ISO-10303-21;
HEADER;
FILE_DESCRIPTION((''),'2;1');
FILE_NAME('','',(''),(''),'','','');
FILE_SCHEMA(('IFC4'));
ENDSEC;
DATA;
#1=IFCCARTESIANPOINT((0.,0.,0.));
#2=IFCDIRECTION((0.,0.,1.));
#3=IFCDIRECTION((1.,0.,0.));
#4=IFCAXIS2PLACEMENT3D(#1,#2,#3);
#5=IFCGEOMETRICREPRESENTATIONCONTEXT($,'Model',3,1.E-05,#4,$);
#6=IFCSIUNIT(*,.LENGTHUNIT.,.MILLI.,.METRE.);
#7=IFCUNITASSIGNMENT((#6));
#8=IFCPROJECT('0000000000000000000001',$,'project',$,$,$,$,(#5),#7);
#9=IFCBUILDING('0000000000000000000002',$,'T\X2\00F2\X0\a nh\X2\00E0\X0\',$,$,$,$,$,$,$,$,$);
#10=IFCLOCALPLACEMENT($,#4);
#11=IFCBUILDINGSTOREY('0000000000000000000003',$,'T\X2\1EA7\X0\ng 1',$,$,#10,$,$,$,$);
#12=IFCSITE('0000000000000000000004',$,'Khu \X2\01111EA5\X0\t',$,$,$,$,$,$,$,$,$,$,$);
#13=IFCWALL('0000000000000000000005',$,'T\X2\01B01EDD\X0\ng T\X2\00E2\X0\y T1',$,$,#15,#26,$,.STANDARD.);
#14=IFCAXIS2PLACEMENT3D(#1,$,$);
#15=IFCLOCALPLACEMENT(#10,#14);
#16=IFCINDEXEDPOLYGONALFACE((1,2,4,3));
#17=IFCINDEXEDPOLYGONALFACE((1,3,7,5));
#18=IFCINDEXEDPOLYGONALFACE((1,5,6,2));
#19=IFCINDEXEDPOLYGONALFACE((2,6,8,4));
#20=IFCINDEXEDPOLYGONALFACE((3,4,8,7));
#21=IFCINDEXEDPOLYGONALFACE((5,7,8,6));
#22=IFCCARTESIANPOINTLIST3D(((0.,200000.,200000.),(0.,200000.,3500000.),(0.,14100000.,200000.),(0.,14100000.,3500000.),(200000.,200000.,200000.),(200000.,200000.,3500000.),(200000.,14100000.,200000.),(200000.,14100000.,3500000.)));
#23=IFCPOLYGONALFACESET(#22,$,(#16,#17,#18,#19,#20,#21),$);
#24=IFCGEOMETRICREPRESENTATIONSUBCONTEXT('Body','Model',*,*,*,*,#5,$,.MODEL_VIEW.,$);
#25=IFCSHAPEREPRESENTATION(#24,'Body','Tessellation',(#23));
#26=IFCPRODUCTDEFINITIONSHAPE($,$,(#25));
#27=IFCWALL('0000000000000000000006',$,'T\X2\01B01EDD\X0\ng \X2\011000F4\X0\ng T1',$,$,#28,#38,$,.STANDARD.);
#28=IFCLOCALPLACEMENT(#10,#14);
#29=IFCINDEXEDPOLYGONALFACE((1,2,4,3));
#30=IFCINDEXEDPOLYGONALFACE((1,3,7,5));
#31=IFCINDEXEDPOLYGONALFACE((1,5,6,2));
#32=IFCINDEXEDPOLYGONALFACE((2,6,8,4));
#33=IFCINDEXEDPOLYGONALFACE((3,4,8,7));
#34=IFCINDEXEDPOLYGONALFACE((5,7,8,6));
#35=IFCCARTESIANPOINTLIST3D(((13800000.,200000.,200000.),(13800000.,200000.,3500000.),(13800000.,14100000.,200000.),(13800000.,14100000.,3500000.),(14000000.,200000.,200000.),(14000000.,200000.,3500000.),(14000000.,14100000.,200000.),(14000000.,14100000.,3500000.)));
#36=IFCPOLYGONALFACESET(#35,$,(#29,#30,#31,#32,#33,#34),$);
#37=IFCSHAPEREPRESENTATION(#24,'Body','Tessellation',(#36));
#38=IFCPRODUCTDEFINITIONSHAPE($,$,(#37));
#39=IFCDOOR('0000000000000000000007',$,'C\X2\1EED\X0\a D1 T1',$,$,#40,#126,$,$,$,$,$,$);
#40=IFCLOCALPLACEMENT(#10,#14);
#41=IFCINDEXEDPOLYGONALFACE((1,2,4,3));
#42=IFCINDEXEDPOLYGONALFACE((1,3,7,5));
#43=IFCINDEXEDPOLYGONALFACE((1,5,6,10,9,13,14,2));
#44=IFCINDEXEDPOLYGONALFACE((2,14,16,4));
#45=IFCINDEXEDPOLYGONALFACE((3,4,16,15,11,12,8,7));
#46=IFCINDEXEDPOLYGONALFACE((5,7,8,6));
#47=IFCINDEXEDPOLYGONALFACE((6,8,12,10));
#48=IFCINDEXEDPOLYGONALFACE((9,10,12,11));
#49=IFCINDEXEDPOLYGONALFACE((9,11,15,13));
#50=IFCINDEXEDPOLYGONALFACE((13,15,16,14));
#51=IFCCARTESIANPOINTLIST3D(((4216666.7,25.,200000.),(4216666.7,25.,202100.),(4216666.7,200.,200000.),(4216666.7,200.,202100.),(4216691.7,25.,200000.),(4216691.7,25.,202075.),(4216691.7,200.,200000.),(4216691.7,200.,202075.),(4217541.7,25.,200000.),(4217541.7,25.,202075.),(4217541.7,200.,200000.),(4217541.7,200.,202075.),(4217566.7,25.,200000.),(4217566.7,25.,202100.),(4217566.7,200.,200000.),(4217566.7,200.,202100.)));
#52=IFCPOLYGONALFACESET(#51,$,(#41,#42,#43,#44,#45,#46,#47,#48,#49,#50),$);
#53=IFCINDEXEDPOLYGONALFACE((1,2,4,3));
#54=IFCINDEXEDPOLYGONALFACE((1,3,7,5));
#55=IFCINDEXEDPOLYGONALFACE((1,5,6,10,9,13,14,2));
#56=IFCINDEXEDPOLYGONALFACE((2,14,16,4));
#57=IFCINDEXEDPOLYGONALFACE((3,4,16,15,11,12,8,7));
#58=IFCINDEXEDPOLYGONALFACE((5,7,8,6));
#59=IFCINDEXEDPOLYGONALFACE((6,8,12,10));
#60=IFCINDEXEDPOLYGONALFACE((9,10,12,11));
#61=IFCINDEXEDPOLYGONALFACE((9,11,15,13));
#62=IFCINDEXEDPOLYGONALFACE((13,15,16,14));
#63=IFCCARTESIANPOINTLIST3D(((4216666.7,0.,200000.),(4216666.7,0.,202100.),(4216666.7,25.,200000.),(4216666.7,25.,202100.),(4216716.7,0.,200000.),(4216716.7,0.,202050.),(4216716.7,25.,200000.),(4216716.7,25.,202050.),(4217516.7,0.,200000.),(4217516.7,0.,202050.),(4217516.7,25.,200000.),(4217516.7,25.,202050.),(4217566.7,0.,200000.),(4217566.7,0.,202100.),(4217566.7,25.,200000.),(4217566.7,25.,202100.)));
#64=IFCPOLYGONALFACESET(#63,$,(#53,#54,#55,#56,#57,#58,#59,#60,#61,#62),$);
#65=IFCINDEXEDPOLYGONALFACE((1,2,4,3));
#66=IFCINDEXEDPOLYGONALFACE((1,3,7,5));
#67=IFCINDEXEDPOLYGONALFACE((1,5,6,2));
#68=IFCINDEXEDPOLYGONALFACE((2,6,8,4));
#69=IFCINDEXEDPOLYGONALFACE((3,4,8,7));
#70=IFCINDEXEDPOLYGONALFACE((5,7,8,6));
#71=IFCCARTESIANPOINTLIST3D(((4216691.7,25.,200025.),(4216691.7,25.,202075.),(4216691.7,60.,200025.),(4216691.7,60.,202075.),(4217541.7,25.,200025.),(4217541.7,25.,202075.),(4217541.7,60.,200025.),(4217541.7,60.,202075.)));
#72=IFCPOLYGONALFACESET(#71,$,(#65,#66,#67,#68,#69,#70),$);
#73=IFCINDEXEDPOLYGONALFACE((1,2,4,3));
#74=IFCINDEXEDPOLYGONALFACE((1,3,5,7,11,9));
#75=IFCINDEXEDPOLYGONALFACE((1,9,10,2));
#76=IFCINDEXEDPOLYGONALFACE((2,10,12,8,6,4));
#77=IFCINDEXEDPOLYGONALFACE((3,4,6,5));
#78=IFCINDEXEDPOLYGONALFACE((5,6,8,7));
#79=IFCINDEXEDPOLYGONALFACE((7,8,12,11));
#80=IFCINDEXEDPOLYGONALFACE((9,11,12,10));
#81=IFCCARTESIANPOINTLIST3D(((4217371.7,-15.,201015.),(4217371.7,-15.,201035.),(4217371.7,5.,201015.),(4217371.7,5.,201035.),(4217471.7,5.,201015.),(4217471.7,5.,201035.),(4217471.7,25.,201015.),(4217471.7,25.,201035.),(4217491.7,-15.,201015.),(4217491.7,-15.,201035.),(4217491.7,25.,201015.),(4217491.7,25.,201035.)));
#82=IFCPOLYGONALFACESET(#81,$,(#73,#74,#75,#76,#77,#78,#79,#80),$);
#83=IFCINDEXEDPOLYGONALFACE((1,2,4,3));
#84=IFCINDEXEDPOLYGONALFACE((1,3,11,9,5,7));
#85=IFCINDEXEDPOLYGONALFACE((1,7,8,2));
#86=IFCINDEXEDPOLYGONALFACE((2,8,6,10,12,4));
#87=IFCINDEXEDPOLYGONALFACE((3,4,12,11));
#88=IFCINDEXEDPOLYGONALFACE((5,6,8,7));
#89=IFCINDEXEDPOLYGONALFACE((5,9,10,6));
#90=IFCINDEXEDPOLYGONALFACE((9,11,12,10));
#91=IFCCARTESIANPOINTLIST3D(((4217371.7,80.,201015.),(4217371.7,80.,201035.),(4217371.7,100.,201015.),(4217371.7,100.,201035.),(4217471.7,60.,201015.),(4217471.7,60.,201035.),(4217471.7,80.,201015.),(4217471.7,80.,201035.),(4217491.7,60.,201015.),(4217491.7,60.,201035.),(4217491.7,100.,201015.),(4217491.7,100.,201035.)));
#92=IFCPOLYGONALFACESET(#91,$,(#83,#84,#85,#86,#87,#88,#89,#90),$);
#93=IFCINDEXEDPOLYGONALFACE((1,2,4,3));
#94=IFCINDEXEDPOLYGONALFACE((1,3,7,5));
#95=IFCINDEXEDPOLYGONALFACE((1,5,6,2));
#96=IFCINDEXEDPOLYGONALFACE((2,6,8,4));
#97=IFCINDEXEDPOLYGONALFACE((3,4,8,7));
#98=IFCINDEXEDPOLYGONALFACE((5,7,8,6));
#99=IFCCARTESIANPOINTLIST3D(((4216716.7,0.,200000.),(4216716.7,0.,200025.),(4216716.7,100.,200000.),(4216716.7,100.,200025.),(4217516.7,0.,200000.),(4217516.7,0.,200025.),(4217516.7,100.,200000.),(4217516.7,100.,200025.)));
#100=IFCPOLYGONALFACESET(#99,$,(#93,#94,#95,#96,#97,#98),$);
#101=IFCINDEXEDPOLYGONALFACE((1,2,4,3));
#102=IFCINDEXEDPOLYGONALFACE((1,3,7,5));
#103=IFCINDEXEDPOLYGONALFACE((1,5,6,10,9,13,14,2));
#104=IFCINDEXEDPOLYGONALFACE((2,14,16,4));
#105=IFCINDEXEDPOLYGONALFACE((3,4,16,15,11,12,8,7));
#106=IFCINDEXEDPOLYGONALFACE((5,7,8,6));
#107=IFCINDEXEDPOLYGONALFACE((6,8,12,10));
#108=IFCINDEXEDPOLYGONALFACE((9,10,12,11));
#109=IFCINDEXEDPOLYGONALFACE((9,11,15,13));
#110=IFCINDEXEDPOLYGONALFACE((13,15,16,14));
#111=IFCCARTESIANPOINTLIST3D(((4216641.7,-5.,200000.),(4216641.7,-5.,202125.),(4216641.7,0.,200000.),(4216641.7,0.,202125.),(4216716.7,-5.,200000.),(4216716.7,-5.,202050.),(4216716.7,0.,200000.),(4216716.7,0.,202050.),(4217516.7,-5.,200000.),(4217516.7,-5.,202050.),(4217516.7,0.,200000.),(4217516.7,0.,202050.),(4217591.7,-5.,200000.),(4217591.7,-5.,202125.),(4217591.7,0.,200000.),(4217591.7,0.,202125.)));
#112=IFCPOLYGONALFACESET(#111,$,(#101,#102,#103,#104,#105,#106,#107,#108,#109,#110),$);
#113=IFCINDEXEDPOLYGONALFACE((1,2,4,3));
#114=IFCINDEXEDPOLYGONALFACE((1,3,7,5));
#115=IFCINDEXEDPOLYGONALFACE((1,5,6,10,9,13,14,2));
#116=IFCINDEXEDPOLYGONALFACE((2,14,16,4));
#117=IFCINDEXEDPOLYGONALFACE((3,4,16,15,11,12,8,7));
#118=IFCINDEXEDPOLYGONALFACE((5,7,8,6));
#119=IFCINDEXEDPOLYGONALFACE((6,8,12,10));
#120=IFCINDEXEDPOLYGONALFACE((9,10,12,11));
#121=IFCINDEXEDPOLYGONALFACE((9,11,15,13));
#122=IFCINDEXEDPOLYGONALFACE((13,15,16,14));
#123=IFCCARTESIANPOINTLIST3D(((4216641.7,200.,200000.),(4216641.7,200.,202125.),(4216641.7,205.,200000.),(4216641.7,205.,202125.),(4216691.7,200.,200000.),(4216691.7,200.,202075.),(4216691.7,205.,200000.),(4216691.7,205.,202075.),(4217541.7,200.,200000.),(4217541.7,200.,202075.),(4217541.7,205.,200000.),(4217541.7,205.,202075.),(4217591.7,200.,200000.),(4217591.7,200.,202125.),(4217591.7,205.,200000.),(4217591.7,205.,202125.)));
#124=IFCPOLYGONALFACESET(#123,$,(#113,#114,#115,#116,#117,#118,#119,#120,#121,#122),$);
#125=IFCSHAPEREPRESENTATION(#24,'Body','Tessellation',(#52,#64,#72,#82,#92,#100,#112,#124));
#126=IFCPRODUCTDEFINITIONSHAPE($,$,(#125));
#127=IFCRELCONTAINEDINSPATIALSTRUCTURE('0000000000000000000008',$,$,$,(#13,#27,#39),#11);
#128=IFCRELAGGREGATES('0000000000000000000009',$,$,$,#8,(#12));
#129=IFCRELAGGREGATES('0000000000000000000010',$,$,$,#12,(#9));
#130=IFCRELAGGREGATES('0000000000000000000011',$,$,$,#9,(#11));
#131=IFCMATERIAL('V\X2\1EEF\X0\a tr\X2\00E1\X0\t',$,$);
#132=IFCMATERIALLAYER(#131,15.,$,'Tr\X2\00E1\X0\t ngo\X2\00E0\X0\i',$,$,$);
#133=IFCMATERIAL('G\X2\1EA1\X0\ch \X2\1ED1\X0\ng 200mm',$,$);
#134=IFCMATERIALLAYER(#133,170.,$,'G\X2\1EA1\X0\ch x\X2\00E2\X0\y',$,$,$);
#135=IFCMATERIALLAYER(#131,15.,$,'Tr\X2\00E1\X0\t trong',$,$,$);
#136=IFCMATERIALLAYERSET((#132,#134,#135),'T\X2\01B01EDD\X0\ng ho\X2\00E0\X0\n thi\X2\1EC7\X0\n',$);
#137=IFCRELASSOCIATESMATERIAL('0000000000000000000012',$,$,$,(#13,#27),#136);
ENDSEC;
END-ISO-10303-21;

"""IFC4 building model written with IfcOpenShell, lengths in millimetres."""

from ifc_helpers import new_model, si_unit, frame, origin_with_axes, place, context, subcontext, project, spatial, line, indexed_curve, outline, extrude, material, layer, layer_set, layer_usage, element, save


model = new_model("IFC4")

# Units and contexts
model_context = context("Model", 3, precision=1e-05, world=origin_with_axes())
body_context = subcontext(model_context, "Body", "Model", "MODEL_VIEW")
ifc_project = project(units=[si_unit("LENGTHUNIT", "METRE", prefix="MILLI")], contexts=[model_context])

# Site, building, storey
site = spatial("IfcSite", under=ifc_project, Name="Khu đất")
building = spatial("IfcBuilding", under=site, Name="Tòa nhà")
storey_placement = place(None, origin_with_axes())
storey = spatial("IfcBuildingStorey", under=building, at=storey_placement, Name="Tầng 1")

# Walls
ifc_material_1 = material(Name="Vữa trát")
ifc_layer_1 = layer(ifc_material_1, 15.0, Name="Trát ngoài")
ifc_material_2 = material(Name="Gạch ống 200mm")
ifc_layer_2 = layer(ifc_material_2, 170.0, Name="Gạch xây")
ifc_layer_3 = layer(ifc_material_1, 15.0, Name="Trát trong")
ifc_layer_set = layer_set([ifc_layer_1, ifc_layer_2, ifc_layer_3], Name="Tường hoàn thiện")
ifc_layer_usage_1 = layer_usage(ifc_layer_set, "AXIS2", "POSITIVE", 0.0)
wall_1_placement = place(storey_placement, frame((0.0, 200000.0, 200000.0), z_axis=(0.0, 0.0, 1.0), x_axis=(1.0, 0.0, 0.0)))
element("IfcWall", 1, at=wall_1_placement, inside=storey, material=ifc_layer_usage_1, Name="Tường Tây T1", PredefinedType="STANDARD", context=body_context, shape_type="SweptSolid", body=[
    extrude(outline(indexed_curve([(0.0, 0.0), (0.0, 13900000.0), (200000.0, 13900000.0), (200000.0, 0.0), (0.0, 0.0)], self_intersect=False)), origin_with_axes(), (0.0, 0.0, 1.0), 3300000.0),
])
ifc_layer_usage_2 = layer_usage(ifc_layer_set, "AXIS2", "POSITIVE", 0.0)
wall_2_placement = place(storey_placement, frame((13800000.0, 200000.0, 200000.0), z_axis=(0.0, 0.0, 1.0), x_axis=(1.0, 0.0, 0.0)))
element("IfcWall", 2, at=wall_2_placement, inside=storey, material=ifc_layer_usage_2, Name="Tường Đông T1", PredefinedType="STANDARD", context=body_context, shape_type="SweptSolid", body=[
    extrude(outline(indexed_curve([(0.0, 0.0), (0.0, 13900000.0), (200000.0, 13900000.0), (200000.0, 0.0), (0.0, 0.0)], self_intersect=False)), origin_with_axes(), (0.0, 0.0, 1.0), 3300000.0),
])

# Door
door_1_placement = place(storey_placement, frame((4216666.7, 0.0, 200000.0), z_axis=(0.0, 0.0, 1.0), x_axis=(1.0, 0.0, 0.0)))
element("IfcDoor", 3, at=door_1_placement, inside=storey, Name="Cửa D1 T1", context=body_context, shape_type="SolidModel", body=[
    extrude(outline(indexed_curve([(0.0, 0.0), (0.0, 2100.0), (900.0, 2100.0), (900.0, 0.0), (875.0, 0.0), (875.0, 2075.0), (25.0, 2075.0), (25.0, 0.0)], segments=[line(1, 2, 3, 4, 5, 6, 7, 8, 1)])), frame((0.0, 25.0, 0.0), z_axis=(0.0, -1.0, 0.0), x_axis=(1.0, 0.0, 0.0)), (0.0, 0.0, -1.0), 175.0),
    extrude(outline(indexed_curve([(0.0, 0.0), (0.0, 2100.0), (900.0, 2100.0), (900.0, 0.0), (850.0, 0.0), (850.0, 2050.0), (50.0, 2050.0), (50.0, 0.0)], segments=[line(1, 2, 3, 4, 5, 6, 7, 8, 1)])), frame((0.0, 0.0, 0.0), z_axis=(0.0, -1.0, 0.0), x_axis=(1.0, 0.0, 0.0)), (0.0, 0.0, -1.0), 25.0),
    extrude(outline(indexed_curve([(0.0, 0.0), (850.0, 0.0), (850.0, 35.0), (0.0, 35.0)], segments=[line(1, 2, 3, 4, 1)])), frame((25.0, 25.0, 25.0), z_axis=(0.0, 0.0, 1.0), x_axis=(1.0, 0.0, 0.0)), (0.0, 0.0, 1.0), 2050.0),
    extrude(outline(indexed_curve([(0.0, 0.0), (0.0, -40.0), (-120.0, -40.0), (-120.0, -20.0), (-20.0, -20.0), (-20.0, 0.0)], segments=[line(1, 2, 3, 4, 5, 6, 1)])), frame((825.0, 25.0, 1015.0), z_axis=(0.0, 0.0, 1.0), x_axis=(1.0, 0.0, 0.0)), (0.0, 0.0, 1.0), 20.0),
    extrude(outline(indexed_curve([(0.0, 0.0), (0.0, 40.0), (-120.0, 40.0), (-120.0, 20.0), (-20.0, 20.0), (-20.0, 0.0)], segments=[line(1, 2, 3, 4, 5, 6, 1)])), frame((825.0, 60.0, 1015.0), z_axis=(0.0, 0.0, 1.0), x_axis=(1.0, 0.0, 0.0)), (0.0, 0.0, 1.0), 20.0),
    extrude(outline(indexed_curve([(0.0, 0.0), (800.0, 0.0), (800.0, 100.0), (0.0, 100.0)], segments=[line(1, 2, 3, 4, 1)])), frame((50.0, 0.0, 0.0), z_axis=(0.0, 0.0, 1.0), x_axis=(1.0, 0.0, 0.0)), (0.0, 0.0, 1.0), 25.0),
    extrude(outline(indexed_curve([(0.0, 0.0), (0.0, 2125.0), (950.0, 2125.0), (950.0, 0.0), (875.0, 0.0), (875.0, 2050.0), (75.0, 2050.0), (75.0, 0.0)], segments=[line(1, 2, 3, 4, 5, 6, 7, 8, 1)])), frame((-25.0, -5.0, 0.0), z_axis=(0.0, -1.0, 0.0), x_axis=(1.0, 0.0, 0.0)), (0.0, 0.0, -1.0), 5.0),
    extrude(outline(indexed_curve([(0.0, 0.0), (0.0, 2125.0), (950.0, 2125.0), (950.0, 0.0), (900.0, 0.0), (900.0, 2075.0), (50.0, 2075.0), (50.0, 0.0)], segments=[line(1, 2, 3, 4, 5, 6, 7, 8, 1)])), frame((-25.0, 200.0, 0.0), z_axis=(0.0, -1.0, 0.0), x_axis=(1.0, 0.0, 0.0)), (0.0, 0.0, -1.0), 5.0),
])

save(model, "model.ifc")
